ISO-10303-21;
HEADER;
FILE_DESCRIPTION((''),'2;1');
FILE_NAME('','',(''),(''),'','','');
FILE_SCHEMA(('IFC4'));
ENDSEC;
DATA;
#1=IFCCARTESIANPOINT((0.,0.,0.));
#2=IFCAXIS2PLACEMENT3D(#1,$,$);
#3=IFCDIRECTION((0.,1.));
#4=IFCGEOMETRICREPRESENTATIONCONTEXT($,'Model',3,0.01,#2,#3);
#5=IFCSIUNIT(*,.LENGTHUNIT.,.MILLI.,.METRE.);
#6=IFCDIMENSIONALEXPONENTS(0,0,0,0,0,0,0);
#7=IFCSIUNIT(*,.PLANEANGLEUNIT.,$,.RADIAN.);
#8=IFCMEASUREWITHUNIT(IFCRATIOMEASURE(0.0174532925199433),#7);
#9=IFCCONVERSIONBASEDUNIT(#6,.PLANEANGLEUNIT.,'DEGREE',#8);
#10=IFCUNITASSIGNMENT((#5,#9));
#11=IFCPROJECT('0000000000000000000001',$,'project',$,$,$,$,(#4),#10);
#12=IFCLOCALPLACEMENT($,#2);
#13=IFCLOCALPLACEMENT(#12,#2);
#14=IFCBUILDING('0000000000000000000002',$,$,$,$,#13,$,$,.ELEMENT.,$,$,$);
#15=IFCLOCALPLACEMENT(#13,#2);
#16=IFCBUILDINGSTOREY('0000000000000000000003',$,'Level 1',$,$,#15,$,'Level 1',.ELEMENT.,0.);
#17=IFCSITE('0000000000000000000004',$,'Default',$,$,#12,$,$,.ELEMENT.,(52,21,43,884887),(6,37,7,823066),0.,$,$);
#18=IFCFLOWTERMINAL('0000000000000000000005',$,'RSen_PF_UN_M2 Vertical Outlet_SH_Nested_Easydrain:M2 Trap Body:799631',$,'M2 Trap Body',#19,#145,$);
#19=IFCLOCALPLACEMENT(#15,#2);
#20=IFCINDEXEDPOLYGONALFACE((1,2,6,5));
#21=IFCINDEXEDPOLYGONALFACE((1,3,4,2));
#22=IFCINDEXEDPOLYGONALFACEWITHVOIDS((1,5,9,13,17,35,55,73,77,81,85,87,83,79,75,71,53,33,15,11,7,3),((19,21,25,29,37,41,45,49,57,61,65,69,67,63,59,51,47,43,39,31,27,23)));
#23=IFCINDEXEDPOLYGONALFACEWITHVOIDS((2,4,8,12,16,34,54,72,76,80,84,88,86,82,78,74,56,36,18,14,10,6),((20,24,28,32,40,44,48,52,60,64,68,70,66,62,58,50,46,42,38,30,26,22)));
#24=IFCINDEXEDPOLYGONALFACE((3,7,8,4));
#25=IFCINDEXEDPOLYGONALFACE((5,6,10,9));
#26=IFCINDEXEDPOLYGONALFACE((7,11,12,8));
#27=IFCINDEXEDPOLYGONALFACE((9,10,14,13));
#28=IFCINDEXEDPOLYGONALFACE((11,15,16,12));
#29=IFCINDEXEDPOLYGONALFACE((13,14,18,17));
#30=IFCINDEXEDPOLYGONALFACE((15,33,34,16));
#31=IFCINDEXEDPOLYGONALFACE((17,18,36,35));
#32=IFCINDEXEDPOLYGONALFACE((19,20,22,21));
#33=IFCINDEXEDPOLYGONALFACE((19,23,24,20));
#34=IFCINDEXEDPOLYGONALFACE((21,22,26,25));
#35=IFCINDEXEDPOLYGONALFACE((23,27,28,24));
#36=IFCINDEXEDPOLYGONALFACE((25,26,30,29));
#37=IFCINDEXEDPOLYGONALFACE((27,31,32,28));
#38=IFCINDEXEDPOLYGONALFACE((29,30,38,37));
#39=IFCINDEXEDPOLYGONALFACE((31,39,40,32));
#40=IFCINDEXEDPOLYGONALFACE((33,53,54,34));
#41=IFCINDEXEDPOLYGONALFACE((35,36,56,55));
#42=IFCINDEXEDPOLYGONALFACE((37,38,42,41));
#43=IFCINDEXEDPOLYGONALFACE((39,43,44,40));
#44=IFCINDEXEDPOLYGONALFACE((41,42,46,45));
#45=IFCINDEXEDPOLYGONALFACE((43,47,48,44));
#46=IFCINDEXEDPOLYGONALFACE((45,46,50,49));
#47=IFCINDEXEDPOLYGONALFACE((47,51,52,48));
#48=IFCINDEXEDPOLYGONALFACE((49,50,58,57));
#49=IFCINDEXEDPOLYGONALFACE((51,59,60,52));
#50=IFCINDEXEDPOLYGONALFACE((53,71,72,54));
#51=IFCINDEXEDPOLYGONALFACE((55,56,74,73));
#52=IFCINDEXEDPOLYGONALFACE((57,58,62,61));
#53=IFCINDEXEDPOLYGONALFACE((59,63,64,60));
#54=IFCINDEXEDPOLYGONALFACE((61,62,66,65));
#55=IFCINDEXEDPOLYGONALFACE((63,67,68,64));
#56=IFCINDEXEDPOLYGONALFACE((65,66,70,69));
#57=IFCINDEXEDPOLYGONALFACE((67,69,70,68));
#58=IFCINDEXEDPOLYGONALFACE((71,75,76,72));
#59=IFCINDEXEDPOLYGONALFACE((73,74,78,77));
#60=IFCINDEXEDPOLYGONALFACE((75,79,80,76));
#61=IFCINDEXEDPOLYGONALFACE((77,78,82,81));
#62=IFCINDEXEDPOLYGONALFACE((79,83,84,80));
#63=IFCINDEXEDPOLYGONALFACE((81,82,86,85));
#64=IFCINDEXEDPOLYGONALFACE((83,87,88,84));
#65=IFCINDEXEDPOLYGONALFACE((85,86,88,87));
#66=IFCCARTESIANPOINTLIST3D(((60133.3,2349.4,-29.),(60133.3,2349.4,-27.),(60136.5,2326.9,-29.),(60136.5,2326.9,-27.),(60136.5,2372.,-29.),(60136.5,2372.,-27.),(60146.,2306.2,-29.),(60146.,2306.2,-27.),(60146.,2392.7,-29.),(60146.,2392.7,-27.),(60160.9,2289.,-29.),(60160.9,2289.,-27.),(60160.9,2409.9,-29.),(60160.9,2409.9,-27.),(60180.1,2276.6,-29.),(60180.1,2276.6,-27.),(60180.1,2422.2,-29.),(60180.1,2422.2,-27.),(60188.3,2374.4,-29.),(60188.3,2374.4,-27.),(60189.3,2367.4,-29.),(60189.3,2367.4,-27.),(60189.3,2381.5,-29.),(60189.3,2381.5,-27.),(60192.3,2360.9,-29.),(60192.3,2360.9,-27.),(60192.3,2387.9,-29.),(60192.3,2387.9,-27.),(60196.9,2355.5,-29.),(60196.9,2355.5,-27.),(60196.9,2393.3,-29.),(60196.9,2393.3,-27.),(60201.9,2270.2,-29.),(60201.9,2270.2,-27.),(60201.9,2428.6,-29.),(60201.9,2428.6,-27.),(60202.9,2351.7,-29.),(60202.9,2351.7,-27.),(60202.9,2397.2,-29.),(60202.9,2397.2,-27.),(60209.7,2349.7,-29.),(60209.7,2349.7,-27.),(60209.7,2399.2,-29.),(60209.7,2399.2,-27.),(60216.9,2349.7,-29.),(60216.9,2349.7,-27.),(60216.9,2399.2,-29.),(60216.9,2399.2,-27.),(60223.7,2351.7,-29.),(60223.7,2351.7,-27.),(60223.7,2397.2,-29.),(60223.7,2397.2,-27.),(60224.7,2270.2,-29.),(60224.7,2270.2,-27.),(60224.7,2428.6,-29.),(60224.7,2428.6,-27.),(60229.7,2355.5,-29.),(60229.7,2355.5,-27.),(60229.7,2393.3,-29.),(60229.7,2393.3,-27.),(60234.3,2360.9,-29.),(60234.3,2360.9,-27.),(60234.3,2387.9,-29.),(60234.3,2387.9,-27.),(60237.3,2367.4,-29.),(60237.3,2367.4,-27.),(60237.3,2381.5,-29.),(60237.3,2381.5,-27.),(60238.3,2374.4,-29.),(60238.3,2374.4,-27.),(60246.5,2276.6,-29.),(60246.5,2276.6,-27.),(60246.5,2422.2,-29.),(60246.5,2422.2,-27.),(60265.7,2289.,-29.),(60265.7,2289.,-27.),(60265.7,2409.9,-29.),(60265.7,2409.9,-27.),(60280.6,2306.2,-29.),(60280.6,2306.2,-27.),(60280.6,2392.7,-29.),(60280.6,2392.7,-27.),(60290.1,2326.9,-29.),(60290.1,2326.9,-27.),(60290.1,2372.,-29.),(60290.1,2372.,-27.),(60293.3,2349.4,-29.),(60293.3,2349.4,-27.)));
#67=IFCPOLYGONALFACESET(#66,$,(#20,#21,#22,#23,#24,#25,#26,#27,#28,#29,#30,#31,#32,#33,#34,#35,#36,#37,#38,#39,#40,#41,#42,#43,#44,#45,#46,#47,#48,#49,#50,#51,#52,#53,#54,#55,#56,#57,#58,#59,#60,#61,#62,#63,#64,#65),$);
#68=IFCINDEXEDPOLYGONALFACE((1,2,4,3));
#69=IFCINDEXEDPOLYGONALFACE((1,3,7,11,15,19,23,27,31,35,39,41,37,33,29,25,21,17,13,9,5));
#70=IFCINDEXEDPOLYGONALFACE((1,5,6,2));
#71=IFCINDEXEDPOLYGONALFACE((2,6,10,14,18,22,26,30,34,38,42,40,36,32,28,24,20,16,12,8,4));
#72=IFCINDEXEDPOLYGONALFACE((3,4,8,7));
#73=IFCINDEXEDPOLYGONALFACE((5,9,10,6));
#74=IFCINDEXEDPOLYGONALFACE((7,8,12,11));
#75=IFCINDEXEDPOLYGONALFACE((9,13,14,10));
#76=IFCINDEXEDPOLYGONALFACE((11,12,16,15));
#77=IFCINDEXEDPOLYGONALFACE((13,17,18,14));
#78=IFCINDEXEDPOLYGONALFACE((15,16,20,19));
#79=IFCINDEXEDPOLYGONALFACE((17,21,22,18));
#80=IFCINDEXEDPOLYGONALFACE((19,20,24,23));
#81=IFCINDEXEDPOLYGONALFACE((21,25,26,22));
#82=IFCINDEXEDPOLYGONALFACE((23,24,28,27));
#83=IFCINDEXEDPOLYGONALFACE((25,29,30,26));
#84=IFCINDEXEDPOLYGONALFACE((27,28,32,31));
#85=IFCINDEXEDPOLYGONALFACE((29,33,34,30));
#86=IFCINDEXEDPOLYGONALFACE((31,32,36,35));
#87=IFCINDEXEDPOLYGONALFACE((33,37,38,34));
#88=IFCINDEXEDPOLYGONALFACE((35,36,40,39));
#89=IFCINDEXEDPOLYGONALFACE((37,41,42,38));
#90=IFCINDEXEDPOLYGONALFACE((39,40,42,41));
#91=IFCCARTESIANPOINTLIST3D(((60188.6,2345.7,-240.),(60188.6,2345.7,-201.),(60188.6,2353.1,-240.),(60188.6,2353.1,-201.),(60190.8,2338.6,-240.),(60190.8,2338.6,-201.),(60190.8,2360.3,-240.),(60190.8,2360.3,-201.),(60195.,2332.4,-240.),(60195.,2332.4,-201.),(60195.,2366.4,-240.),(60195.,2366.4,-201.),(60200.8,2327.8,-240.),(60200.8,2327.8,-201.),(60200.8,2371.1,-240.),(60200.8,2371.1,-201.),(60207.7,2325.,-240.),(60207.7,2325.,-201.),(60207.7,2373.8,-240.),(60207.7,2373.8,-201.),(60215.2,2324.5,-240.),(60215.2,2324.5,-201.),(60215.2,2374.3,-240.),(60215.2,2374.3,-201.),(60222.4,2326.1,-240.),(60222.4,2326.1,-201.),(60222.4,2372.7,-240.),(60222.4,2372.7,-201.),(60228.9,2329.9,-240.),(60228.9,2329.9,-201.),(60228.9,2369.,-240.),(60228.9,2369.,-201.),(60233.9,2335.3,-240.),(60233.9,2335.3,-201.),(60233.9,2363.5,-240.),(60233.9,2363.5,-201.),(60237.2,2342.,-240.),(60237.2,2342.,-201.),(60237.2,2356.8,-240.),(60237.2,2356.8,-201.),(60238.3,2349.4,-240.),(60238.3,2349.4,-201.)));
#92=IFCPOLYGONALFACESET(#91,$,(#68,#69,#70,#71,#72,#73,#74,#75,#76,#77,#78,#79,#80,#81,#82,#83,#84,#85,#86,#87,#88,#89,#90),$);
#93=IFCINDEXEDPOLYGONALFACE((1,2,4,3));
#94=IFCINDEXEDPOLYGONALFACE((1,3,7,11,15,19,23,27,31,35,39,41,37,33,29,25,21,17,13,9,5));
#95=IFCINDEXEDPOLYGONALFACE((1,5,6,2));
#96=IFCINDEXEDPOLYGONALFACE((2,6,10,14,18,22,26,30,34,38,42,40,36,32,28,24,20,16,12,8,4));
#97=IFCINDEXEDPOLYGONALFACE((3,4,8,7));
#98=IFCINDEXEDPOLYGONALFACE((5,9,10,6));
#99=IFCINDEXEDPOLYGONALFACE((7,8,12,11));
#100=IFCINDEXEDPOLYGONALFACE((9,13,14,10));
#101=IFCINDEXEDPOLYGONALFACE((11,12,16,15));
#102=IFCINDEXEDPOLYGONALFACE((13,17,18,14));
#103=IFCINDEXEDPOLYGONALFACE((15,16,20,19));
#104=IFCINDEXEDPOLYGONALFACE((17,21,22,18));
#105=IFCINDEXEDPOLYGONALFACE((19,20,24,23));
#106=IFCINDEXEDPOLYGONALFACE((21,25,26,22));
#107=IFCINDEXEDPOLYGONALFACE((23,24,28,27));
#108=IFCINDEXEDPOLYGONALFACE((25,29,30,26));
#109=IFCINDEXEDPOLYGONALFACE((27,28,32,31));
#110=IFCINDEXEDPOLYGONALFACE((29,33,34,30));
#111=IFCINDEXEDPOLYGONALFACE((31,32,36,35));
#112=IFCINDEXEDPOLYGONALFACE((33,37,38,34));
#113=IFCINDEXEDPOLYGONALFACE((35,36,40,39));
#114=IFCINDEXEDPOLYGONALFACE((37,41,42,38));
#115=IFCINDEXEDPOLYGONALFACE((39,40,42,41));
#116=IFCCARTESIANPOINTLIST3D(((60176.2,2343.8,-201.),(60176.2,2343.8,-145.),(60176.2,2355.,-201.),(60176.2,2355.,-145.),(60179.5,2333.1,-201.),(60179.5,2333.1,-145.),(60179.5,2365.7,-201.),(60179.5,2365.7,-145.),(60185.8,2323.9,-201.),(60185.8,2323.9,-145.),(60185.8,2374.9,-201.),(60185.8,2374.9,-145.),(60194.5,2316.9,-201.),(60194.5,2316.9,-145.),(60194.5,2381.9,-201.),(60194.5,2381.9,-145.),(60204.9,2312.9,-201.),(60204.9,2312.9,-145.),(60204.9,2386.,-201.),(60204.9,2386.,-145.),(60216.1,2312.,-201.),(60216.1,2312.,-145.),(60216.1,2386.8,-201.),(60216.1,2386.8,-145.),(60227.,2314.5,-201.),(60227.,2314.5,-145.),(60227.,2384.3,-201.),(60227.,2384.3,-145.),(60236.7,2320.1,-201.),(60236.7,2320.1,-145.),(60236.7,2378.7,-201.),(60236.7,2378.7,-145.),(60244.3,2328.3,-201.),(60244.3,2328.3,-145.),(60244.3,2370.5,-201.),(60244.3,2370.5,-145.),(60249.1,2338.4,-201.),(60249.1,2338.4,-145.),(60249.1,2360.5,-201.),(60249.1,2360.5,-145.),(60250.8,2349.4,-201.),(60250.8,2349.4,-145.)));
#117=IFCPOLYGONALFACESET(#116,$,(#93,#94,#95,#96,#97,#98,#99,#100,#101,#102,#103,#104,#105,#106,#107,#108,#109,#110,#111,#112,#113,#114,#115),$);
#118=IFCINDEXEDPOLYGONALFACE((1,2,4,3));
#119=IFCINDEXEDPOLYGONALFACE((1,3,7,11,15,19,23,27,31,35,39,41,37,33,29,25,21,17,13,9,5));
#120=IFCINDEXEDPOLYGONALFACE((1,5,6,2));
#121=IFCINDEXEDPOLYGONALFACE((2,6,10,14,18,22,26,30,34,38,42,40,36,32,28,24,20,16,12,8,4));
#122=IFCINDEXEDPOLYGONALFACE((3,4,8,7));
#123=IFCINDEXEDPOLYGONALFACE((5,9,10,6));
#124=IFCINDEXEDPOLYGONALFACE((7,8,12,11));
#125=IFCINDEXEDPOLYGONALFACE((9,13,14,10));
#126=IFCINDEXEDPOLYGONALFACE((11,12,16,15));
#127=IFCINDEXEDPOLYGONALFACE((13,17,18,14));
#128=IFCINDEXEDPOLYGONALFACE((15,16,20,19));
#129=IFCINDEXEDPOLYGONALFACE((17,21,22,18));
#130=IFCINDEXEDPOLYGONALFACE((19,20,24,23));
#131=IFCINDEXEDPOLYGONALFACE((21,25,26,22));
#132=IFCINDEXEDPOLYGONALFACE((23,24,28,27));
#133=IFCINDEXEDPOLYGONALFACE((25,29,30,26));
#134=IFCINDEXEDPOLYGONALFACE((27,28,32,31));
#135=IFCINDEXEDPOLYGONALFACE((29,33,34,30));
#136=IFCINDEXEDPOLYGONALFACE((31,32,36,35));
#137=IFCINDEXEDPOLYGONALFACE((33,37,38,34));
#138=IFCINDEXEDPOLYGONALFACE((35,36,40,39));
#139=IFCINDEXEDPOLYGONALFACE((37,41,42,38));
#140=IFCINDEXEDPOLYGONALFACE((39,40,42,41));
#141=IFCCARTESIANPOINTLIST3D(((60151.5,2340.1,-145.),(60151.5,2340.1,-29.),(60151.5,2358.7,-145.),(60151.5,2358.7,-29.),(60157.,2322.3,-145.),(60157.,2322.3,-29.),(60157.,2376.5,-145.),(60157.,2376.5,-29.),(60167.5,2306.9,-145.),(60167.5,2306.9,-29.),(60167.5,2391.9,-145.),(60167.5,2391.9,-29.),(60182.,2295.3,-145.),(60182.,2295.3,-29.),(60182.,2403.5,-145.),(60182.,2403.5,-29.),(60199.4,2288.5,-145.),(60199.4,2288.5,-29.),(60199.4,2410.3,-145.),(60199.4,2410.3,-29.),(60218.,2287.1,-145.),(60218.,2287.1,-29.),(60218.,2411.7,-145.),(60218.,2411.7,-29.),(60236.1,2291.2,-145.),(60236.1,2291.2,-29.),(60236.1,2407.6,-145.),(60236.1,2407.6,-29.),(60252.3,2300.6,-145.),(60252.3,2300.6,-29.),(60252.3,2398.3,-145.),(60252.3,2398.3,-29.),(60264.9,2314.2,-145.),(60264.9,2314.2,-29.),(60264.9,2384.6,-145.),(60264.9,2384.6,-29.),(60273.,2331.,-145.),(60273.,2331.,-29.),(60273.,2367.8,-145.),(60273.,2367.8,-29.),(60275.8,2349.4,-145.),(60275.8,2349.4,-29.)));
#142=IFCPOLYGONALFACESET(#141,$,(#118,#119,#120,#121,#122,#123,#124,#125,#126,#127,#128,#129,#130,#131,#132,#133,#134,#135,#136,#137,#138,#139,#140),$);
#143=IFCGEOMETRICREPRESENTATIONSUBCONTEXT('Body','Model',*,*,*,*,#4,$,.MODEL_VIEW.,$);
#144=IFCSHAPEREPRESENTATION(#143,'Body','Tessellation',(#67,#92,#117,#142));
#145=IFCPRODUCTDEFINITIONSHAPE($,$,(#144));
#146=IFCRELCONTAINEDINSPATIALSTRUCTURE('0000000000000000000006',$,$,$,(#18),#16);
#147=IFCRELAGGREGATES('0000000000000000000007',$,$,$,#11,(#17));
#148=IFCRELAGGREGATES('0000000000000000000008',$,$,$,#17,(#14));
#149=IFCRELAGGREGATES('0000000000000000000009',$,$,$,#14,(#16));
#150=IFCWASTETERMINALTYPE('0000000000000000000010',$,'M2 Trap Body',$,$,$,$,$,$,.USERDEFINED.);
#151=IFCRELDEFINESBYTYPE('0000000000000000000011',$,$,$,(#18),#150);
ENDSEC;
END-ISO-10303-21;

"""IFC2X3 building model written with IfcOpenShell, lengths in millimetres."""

from ifc_helpers import new_model, entity, si_unit, converted_unit, direction, frame, frame_2d, origin, origin_2d_with_axis, place, context, subcontext, project, spatial, circle_curve, parameter, trimmed, segment, composite_curve, circle, outline, extrude, source, transform, mapped, type_object, type_shapes, element, save


model = new_model("IFC2X3")

# Units and contexts
model_context = context("Model", 3, precision=0.01, world=origin(), true_north=direction((0.0, 1.0)))
body_context = subcontext(model_context, "Body", "Model", "MODEL_VIEW")
ifc_project = project(units=[si_unit("LENGTHUNIT", "METRE", prefix="MILLI"), converted_unit("PLANEANGLEUNIT", "DEGREE", entity("IfcRatioMeasure", 0.0174532925199433), si_unit("PLANEANGLEUNIT", "RADIAN"), dimensions=[0, 0, 0, 0, 0, 0, 0])], contexts=[model_context])

# Site, building, storey
site_placement = place(None, origin())
site = spatial("IfcSite", under=ifc_project, at=site_placement, Name="Default", CompositionType="ELEMENT", RefLatitude=(52, 21, 43, 884887), RefLongitude=(6, 37, 7, 823066), RefElevation=0.0)
building_placement = place(site_placement, origin())
building = spatial("IfcBuilding", under=site, at=building_placement, CompositionType="ELEMENT")
storey_placement = place(building_placement, origin())
storey = spatial("IfcBuildingStorey", under=building, at=storey_placement, Name="Level 1", LongName="Level 1", CompositionType="ELEMENT", Elevation=0.0)

# Flow terminal
waste_terminal_type_1 = type_object("IfcWasteTerminalType", Name="M2 Trap Body", PredefinedType="USERDEFINED")
shared_shape_1 = source(origin(), body_context, "Body", "SweptSolid", [
    extrude(outline(composite_curve([segment(trimmed(circle_curve(origin_2d_with_axis(), 80.0), [parameter(0.0)], [parameter(180.0)], True, "PARAMETER"), True, "CONTINUOUS"), segment(trimmed(circle_curve(origin_2d_with_axis(), 80.0), [parameter(180.0)], [parameter(360.0)], True, "PARAMETER"), True, "CONTINUOUS")], self_intersect=False), holes=[composite_curve([segment(trimmed(circle_curve(frame_2d((0.0, 25.0), x_axis=(1.0, 0.0)), 25.0), [parameter(180.0)], [parameter(360.0)], True, "PARAMETER"), False, "CONTINUOUS"), segment(trimmed(circle_curve(frame_2d((0.0, 25.0), x_axis=(1.0, 0.0)), 25.0), [parameter(0.0)], [parameter(180.0)], True, "PARAMETER"), False, "CONTINUOUS")], self_intersect=False)]), frame((0.0, -25.0, -2.0)), (0.0, 0.0, 1.0), 2.0),
    extrude(circle(Radius=25.0, at=frame_2d((0.0, 0.0), x_axis=(1.0, 0.0))), frame((0.0, -25.0, -213.0)), (0.0, 0.0, 1.0), 39.0),
    extrude(circle(Radius=37.5, at=frame_2d((0.0, 0.0), x_axis=(1.0, 0.0))), frame((0.0, -25.0, -174.0)), (0.0, 0.0, 1.0), 56.0),
    extrude(circle(Radius=62.5, at=frame_2d((0.0, 0.0), x_axis=(1.0, 0.0))), frame((0.0, -25.0, -118.0)), (0.0, 0.0, 1.0), 116.0),
])
type_shapes(waste_terminal_type_1, [shared_shape_1])
for number, where, name in (
    (1, (60213.3, 2374.4, -27.0), "RSen_PF_UN_M2 Vertical Outlet_SH_Nested_Easydrain:M2 Trap Body:799631"),
):
    element("IfcFlowTerminal", number, at=place(storey_placement, frame(where)), inside=storey, type_object=waste_terminal_type_1, Name=name, ObjectType="M2 Trap Body", context=body_context, shape_type="MappedRepresentation", body=[
        mapped(shared_shape_1, transform((0.0, 0.0, 0.0), scale=1.0)),
    ])

save(model, "model.ifc")
